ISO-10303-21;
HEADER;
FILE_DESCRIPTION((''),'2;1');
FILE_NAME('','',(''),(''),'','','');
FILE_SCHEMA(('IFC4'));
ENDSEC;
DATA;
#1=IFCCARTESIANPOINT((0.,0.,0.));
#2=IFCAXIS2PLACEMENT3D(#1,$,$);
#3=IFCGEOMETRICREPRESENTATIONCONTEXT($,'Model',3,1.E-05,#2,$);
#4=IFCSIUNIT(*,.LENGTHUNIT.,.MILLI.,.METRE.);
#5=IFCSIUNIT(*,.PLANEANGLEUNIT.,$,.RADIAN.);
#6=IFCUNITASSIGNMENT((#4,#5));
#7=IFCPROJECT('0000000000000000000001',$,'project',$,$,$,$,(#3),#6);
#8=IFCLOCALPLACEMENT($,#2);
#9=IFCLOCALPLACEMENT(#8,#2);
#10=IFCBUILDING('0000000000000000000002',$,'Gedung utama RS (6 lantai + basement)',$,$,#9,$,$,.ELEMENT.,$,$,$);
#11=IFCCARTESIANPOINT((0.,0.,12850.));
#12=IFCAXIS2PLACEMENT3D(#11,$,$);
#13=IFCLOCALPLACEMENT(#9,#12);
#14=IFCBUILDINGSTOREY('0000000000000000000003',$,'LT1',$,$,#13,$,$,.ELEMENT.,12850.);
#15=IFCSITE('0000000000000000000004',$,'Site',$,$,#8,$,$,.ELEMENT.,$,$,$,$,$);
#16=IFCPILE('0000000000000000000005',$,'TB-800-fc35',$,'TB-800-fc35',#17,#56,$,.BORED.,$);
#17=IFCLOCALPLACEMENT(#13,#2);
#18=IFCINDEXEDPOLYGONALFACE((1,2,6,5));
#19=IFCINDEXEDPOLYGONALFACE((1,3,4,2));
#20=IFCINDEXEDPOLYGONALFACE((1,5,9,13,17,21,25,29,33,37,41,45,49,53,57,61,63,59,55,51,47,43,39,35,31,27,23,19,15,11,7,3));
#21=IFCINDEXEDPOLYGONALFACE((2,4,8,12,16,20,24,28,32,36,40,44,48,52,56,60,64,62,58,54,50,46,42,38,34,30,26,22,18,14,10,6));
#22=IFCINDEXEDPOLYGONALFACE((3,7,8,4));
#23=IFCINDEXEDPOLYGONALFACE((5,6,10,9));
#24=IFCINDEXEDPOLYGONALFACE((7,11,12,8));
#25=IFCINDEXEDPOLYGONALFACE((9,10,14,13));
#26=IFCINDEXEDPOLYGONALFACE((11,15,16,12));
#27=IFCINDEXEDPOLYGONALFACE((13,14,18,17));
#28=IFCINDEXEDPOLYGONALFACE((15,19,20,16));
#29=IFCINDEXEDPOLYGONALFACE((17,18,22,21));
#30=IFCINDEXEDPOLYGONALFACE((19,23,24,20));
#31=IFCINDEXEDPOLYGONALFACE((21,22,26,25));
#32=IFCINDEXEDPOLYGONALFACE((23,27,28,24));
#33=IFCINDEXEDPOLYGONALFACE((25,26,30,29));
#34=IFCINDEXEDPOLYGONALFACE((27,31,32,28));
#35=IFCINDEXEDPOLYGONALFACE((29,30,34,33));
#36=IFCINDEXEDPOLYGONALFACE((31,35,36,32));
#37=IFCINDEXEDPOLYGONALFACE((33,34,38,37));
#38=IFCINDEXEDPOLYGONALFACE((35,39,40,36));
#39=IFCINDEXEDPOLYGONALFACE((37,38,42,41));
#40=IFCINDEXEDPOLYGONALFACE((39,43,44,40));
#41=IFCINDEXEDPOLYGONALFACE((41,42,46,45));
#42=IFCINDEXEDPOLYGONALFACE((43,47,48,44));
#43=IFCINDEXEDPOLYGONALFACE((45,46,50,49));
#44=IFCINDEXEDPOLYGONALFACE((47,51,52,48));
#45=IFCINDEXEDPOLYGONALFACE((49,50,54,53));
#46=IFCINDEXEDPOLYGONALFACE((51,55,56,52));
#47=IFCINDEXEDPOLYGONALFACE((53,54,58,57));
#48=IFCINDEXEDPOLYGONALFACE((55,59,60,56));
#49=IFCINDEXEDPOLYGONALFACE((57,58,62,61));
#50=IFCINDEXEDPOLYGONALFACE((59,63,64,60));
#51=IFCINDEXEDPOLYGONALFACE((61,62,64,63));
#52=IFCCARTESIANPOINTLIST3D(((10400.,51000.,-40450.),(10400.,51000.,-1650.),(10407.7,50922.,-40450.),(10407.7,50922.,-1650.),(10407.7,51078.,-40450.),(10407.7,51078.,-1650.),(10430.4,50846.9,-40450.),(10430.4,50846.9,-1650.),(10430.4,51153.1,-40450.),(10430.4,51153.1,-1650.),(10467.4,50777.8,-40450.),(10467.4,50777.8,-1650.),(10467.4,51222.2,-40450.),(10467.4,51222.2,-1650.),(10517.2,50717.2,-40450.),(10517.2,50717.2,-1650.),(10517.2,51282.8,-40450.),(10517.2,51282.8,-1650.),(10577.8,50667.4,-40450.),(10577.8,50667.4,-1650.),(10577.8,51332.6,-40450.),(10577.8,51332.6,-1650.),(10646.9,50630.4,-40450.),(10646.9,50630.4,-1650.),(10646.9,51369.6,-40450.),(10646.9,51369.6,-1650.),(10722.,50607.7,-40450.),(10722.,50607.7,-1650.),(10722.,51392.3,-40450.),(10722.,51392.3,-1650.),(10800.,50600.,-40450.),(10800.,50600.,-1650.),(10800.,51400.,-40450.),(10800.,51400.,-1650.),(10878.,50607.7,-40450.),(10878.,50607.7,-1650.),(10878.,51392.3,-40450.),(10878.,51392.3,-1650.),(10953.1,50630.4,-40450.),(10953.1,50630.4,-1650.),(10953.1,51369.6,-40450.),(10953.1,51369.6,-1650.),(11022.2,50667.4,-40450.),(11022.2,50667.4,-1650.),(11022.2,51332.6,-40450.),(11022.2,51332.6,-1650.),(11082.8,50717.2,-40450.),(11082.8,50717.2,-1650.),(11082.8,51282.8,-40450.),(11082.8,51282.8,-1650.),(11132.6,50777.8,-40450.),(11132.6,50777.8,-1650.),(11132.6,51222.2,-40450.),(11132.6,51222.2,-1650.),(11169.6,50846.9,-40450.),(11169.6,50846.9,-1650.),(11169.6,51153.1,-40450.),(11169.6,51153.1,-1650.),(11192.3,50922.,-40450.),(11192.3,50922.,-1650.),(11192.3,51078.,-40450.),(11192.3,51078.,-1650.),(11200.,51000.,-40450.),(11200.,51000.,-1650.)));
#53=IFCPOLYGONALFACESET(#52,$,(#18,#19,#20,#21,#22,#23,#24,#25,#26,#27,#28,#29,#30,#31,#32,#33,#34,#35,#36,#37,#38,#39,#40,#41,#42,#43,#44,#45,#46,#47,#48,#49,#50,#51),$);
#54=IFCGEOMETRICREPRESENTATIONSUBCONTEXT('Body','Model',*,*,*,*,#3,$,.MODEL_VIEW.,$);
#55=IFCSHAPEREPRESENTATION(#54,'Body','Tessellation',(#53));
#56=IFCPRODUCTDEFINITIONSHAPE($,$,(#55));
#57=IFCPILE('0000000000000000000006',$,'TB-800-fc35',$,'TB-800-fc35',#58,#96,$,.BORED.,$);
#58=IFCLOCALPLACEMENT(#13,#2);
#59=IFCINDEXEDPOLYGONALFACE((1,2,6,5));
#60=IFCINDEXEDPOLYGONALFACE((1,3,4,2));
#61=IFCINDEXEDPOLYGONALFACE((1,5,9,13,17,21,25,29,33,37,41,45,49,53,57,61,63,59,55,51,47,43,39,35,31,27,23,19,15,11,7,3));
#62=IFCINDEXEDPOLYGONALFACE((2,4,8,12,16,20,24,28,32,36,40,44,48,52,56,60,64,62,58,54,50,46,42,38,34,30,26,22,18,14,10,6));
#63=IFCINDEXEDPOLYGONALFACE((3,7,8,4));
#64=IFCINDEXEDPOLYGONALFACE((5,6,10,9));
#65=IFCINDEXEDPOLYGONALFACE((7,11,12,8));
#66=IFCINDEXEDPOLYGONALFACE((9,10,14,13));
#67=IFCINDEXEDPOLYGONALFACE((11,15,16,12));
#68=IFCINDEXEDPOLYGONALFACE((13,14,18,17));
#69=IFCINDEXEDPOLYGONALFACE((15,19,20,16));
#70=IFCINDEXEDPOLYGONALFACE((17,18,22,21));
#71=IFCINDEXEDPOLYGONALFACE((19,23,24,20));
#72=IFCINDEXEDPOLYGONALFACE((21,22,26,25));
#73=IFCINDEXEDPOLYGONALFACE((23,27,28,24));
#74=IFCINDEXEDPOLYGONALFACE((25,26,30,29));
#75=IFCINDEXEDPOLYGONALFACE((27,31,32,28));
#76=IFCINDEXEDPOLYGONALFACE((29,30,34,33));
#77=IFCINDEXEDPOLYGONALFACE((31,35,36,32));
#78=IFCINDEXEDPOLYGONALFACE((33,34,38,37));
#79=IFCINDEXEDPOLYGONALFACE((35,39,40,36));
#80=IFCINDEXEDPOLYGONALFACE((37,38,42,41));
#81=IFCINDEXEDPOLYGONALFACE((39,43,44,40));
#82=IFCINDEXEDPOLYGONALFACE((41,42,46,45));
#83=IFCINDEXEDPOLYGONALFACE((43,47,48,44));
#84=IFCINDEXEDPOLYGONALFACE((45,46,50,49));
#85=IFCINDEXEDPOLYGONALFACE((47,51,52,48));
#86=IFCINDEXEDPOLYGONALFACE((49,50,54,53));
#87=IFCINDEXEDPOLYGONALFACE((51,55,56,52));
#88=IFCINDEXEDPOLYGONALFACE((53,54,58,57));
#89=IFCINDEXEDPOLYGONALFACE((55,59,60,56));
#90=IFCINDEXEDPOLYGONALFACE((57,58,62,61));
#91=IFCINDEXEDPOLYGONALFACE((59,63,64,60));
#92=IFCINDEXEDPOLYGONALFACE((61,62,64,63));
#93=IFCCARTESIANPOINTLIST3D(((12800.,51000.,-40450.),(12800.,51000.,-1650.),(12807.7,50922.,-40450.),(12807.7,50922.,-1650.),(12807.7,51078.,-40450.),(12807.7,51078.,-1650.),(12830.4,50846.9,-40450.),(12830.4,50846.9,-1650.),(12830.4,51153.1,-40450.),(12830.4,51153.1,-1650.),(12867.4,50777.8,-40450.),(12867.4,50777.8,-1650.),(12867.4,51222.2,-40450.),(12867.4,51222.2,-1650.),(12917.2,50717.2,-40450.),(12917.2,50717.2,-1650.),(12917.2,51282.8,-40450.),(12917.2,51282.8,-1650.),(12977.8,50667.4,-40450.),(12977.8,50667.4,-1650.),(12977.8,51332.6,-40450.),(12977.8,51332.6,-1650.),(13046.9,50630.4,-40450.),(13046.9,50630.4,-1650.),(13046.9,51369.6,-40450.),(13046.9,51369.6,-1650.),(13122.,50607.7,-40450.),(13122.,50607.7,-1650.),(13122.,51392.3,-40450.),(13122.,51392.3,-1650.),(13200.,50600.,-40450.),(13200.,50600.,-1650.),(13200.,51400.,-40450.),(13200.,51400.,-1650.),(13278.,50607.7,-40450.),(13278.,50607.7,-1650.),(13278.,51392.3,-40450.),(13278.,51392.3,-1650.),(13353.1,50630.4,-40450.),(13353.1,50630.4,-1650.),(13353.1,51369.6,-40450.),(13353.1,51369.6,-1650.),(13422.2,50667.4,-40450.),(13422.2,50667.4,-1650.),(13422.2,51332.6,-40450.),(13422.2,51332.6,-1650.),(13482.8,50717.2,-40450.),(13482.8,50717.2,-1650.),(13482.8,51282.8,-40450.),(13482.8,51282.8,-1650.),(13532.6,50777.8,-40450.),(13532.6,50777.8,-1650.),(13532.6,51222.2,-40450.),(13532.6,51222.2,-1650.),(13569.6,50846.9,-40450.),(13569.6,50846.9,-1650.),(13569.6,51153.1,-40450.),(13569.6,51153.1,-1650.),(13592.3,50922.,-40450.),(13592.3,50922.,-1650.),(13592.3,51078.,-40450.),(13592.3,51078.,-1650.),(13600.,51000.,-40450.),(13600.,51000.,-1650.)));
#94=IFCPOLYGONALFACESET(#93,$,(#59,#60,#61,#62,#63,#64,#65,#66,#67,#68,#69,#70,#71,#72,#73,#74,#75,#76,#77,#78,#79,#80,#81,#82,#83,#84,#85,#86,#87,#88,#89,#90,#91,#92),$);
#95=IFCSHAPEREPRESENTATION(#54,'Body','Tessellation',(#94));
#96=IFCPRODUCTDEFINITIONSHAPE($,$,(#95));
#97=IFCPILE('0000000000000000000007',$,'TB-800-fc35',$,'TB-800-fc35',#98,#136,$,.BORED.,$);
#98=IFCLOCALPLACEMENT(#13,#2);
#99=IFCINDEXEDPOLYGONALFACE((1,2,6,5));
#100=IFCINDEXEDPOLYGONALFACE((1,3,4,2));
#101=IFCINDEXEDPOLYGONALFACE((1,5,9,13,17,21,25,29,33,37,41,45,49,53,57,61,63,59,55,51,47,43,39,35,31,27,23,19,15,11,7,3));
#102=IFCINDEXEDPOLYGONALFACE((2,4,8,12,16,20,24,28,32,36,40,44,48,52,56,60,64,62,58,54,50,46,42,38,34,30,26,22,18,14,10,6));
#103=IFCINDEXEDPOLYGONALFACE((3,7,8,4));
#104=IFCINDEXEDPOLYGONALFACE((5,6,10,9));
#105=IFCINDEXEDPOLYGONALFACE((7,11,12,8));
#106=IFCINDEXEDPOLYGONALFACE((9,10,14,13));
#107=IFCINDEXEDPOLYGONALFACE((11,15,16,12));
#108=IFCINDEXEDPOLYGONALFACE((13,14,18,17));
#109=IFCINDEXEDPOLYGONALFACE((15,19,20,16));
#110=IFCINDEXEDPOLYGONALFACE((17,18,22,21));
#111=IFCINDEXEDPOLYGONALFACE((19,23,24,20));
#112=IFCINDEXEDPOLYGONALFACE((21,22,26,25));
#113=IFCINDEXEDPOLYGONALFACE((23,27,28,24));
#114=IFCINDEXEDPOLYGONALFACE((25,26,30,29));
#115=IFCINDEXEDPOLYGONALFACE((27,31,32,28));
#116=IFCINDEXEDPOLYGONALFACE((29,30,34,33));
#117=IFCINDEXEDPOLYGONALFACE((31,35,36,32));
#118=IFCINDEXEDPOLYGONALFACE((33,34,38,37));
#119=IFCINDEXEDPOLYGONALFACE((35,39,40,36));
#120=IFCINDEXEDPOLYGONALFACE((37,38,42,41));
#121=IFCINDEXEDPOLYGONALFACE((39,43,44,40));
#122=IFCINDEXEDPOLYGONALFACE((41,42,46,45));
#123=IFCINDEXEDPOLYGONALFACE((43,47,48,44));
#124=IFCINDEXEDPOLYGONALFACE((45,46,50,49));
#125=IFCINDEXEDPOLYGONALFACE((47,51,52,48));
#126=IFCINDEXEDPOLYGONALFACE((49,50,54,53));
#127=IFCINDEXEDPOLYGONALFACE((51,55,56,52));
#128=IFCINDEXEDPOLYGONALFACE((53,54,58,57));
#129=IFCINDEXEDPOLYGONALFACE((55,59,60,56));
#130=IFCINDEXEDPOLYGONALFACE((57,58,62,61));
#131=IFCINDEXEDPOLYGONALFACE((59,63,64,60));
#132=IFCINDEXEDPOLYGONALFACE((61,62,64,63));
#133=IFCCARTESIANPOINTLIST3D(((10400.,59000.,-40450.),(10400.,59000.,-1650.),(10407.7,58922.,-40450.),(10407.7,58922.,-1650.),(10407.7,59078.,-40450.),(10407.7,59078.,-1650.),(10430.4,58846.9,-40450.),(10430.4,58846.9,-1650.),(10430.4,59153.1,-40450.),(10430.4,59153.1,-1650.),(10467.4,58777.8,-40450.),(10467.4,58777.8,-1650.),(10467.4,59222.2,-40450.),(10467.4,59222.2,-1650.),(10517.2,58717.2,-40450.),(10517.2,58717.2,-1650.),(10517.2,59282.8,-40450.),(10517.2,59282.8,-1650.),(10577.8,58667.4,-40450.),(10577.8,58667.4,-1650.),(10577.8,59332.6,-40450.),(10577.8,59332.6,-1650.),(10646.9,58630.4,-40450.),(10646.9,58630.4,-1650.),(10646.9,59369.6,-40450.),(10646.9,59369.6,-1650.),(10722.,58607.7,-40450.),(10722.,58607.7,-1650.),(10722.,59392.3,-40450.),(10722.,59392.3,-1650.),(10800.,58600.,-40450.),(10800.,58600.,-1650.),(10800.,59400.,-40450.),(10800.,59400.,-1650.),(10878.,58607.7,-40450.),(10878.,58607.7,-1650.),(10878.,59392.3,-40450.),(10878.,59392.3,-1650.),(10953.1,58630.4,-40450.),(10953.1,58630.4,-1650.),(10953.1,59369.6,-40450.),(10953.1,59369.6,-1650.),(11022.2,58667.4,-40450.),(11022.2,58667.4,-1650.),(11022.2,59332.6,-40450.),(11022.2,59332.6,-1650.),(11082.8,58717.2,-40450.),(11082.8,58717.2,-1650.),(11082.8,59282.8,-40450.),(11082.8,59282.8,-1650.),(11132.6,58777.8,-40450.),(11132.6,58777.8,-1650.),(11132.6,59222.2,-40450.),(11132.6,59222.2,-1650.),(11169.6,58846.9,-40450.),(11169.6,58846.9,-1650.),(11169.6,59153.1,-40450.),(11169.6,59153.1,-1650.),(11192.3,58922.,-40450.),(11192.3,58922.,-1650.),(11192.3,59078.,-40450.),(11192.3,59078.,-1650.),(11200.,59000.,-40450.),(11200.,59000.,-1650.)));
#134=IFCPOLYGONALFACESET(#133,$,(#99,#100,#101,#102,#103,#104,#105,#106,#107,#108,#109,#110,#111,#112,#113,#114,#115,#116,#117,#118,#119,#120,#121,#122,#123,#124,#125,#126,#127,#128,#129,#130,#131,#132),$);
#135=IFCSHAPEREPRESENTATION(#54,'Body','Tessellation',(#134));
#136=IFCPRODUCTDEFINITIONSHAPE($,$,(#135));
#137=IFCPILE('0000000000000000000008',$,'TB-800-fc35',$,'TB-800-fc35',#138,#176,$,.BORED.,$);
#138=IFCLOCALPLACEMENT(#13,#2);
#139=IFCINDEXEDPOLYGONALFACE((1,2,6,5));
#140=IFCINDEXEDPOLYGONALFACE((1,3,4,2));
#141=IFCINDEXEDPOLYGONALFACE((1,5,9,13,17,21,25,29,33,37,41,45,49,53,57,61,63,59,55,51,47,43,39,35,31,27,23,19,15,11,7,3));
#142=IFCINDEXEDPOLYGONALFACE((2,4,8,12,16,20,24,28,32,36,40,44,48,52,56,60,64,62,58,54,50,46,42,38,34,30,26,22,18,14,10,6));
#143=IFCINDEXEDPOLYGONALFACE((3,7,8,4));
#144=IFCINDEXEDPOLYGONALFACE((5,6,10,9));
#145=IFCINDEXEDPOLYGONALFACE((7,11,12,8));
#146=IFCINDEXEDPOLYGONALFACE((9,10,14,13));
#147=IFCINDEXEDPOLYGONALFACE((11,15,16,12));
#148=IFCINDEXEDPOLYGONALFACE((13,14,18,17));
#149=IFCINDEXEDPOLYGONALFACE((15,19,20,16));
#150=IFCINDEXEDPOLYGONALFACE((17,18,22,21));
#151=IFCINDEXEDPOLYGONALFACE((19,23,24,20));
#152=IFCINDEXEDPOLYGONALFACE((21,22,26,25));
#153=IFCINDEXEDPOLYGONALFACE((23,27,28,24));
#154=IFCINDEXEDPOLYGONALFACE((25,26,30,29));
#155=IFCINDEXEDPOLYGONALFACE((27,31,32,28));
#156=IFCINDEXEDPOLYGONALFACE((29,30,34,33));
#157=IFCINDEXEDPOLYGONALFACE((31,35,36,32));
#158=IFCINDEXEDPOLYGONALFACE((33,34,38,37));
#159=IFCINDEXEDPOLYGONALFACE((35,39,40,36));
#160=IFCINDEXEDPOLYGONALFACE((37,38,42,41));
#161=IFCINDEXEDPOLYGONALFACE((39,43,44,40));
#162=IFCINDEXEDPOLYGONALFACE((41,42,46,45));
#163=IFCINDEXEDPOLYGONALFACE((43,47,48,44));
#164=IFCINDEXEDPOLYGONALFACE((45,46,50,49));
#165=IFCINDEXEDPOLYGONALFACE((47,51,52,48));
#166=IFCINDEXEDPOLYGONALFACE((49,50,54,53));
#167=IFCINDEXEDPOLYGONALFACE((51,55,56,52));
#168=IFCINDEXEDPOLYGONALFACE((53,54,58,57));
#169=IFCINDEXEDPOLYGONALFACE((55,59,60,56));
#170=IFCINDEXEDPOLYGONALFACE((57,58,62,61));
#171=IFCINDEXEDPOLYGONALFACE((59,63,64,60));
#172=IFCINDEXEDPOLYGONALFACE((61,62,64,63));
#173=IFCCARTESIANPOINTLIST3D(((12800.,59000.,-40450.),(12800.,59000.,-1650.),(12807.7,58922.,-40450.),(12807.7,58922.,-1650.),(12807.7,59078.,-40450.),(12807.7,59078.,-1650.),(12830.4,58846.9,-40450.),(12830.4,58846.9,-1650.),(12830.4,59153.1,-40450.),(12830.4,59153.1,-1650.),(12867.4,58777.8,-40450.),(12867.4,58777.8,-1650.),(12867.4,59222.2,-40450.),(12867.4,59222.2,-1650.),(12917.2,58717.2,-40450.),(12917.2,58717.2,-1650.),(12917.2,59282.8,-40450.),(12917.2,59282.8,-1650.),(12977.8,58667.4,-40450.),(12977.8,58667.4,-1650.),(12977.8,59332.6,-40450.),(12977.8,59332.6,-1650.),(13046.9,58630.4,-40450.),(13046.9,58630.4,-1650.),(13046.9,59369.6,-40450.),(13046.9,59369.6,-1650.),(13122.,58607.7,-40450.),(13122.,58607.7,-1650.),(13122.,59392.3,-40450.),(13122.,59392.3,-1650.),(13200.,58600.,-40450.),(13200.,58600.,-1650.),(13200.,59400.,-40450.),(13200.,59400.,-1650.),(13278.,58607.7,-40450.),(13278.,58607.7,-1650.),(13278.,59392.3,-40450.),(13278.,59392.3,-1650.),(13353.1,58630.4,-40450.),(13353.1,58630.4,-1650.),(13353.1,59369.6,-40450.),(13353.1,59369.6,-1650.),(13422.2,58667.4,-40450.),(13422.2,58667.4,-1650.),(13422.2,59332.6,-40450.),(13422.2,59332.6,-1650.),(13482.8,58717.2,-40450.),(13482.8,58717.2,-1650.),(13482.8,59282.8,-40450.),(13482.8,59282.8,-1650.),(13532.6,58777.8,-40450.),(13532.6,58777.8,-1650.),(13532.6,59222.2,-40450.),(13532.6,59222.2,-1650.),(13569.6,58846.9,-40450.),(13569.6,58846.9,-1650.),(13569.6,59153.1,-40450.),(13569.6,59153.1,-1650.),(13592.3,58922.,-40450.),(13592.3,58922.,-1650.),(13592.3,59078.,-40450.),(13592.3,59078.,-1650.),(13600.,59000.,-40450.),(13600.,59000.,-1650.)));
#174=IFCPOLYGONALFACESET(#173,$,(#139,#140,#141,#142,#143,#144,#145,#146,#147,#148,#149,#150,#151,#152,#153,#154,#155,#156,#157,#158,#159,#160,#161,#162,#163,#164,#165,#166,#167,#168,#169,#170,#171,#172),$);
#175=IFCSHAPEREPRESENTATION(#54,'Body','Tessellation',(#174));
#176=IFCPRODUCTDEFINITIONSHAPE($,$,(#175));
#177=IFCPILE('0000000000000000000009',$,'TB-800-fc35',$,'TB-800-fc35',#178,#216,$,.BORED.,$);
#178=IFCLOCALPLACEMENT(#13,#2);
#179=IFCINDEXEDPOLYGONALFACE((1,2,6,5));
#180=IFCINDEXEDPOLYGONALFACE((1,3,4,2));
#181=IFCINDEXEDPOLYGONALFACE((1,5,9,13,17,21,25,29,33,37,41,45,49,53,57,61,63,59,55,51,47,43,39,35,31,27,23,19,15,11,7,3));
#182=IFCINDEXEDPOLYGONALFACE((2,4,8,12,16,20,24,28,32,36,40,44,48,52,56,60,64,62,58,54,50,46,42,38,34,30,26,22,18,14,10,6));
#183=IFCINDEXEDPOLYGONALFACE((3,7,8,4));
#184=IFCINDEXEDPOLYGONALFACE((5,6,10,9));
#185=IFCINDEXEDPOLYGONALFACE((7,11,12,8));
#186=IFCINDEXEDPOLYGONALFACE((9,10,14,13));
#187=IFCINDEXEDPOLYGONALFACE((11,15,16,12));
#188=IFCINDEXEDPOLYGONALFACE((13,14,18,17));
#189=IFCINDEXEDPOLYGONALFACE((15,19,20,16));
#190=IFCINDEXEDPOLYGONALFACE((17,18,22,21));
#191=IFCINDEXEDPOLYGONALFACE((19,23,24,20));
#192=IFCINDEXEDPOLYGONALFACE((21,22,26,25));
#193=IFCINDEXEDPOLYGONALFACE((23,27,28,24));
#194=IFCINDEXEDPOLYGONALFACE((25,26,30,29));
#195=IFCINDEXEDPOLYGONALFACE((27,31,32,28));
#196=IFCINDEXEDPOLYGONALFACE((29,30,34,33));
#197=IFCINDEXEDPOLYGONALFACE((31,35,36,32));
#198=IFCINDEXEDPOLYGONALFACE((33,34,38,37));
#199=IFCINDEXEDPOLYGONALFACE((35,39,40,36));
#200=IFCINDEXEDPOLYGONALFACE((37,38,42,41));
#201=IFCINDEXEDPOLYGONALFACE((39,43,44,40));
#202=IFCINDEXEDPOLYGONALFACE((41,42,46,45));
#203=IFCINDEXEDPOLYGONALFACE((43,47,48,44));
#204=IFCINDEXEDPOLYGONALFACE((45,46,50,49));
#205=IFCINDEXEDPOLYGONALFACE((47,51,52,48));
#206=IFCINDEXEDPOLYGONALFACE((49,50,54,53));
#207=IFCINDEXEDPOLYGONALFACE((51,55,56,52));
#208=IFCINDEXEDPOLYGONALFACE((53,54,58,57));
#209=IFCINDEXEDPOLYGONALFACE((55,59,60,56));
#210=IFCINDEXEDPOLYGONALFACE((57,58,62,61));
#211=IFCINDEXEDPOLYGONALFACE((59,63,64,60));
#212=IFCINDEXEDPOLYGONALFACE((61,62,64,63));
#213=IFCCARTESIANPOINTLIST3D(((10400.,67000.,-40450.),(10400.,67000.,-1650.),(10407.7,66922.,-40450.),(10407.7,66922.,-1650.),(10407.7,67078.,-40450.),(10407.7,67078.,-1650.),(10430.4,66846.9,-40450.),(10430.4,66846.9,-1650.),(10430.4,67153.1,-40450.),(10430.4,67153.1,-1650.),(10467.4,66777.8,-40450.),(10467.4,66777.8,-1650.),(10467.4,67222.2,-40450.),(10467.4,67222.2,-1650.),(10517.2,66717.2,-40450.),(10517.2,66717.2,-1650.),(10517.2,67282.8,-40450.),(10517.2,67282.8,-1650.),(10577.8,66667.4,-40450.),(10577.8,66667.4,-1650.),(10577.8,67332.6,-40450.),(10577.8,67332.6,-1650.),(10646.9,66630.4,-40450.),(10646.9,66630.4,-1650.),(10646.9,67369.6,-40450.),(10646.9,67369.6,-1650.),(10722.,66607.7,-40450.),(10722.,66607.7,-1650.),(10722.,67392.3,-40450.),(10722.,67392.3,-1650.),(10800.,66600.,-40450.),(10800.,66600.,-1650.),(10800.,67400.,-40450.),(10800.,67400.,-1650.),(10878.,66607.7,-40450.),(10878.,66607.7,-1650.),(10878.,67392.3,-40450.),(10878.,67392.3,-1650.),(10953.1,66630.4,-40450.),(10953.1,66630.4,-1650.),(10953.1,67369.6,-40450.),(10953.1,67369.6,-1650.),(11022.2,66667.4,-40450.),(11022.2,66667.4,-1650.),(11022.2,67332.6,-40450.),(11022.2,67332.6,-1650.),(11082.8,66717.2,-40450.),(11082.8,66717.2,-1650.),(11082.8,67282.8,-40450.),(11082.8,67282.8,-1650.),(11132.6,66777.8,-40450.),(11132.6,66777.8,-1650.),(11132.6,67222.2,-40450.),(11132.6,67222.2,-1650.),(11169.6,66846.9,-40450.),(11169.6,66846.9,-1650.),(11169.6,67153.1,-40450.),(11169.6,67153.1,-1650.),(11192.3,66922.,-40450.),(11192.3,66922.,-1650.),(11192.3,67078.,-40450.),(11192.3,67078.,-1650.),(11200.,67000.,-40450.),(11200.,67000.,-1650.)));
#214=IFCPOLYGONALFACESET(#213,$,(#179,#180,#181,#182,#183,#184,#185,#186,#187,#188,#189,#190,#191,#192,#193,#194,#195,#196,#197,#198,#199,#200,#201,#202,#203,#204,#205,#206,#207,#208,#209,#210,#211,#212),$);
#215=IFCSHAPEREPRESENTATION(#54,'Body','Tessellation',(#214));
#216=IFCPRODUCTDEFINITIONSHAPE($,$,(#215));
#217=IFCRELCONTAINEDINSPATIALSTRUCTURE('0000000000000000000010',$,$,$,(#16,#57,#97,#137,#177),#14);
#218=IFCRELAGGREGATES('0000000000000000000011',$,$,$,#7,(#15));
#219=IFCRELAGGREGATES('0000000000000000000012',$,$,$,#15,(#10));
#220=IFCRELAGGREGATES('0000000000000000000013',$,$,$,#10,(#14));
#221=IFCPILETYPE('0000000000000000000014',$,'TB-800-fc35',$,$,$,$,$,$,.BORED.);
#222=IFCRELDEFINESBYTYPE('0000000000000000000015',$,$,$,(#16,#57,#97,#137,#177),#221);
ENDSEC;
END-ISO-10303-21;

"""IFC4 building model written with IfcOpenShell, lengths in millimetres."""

from ifc_helpers import new_model, si_unit, frame, origin, origin_2d, place, context, subcontext, project, spatial, circle, extrude, material_profile, profile_set, profile_usage, type_object, element, save


model = new_model("IFC4")

# Units and contexts
model_context = context("Model", 3, precision=1e-05, world=origin())
body_context = subcontext(model_context, "Body", "Model", "MODEL_VIEW")
ifc_project = project(units=[si_unit("LENGTHUNIT", "METRE", prefix="MILLI"), si_unit("PLANEANGLEUNIT", "RADIAN")], contexts=[model_context])

# Site, building, storey
site_placement = place(None, origin())
site = spatial("IfcSite", under=ifc_project, at=site_placement, Name="Site", CompositionType="ELEMENT")
building_placement = place(site_placement, origin())
building = spatial("IfcBuilding", under=site, at=building_placement, Name="Gedung utama RS (6 lantai + basement)", CompositionType="ELEMENT")
storey_placement = place(building_placement, frame((0.0, 0.0, 12850.0)))
storey = spatial("IfcBuildingStorey", under=building, at=storey_placement, Name="LT1", CompositionType="ELEMENT", Elevation=12850.0)

# Piles
ifc_material_profile = material_profile(None, circle(Radius=400.0, at=origin_2d()), Name="TB-800-fc35")
ifc_profile_set = profile_set([ifc_material_profile], Name="TB-800-fc35")
ifc_profile_usage = profile_usage(ifc_profile_set, cardinal=5)
pile_type = type_object("IfcPileType", Name="TB-800-fc35", PredefinedType="BORED", material=ifc_profile_set)
for number, where, z_axis, x_axis, name in (
    (1, (10800.0, 51000.0, -40450.0), (0.0, 0.0, 1.0), (1.0, 0.0, 0.0), "TB-800-fc35"),
    (2, (13200.0, 51000.0, -40450.0), (0.0, 0.0, 1.0), (1.0, 0.0, 0.0), "TB-800-fc35"),
    (3, (10800.0, 59000.0, -40450.0), (0.0, 0.0, 1.0), (1.0, 0.0, 0.0), "TB-800-fc35"),
    (4, (13200.0, 59000.0, -40450.0), (0.0, 0.0, 1.0), (1.0, 0.0, 0.0), "TB-800-fc35"),
    (5, (10800.0, 67000.0, -40450.0), (0.0, 0.0, 1.0), (1.0, 0.0, 0.0), "TB-800-fc35"),
):
    element("IfcPile", number, at=place(storey_placement, frame(where, z_axis=z_axis, x_axis=x_axis)), inside=storey, type_object=pile_type, material=ifc_profile_usage, Name=name, ObjectType="TB-800-fc35", PredefinedType="BORED", context=body_context, shape_type="SweptSolid", body=[
        extrude(circle(Radius=400.0, at=origin_2d()), origin(), (0.0, 0.0, 1.0), 38800.0),
    ])

save(model, "model.ifc")
